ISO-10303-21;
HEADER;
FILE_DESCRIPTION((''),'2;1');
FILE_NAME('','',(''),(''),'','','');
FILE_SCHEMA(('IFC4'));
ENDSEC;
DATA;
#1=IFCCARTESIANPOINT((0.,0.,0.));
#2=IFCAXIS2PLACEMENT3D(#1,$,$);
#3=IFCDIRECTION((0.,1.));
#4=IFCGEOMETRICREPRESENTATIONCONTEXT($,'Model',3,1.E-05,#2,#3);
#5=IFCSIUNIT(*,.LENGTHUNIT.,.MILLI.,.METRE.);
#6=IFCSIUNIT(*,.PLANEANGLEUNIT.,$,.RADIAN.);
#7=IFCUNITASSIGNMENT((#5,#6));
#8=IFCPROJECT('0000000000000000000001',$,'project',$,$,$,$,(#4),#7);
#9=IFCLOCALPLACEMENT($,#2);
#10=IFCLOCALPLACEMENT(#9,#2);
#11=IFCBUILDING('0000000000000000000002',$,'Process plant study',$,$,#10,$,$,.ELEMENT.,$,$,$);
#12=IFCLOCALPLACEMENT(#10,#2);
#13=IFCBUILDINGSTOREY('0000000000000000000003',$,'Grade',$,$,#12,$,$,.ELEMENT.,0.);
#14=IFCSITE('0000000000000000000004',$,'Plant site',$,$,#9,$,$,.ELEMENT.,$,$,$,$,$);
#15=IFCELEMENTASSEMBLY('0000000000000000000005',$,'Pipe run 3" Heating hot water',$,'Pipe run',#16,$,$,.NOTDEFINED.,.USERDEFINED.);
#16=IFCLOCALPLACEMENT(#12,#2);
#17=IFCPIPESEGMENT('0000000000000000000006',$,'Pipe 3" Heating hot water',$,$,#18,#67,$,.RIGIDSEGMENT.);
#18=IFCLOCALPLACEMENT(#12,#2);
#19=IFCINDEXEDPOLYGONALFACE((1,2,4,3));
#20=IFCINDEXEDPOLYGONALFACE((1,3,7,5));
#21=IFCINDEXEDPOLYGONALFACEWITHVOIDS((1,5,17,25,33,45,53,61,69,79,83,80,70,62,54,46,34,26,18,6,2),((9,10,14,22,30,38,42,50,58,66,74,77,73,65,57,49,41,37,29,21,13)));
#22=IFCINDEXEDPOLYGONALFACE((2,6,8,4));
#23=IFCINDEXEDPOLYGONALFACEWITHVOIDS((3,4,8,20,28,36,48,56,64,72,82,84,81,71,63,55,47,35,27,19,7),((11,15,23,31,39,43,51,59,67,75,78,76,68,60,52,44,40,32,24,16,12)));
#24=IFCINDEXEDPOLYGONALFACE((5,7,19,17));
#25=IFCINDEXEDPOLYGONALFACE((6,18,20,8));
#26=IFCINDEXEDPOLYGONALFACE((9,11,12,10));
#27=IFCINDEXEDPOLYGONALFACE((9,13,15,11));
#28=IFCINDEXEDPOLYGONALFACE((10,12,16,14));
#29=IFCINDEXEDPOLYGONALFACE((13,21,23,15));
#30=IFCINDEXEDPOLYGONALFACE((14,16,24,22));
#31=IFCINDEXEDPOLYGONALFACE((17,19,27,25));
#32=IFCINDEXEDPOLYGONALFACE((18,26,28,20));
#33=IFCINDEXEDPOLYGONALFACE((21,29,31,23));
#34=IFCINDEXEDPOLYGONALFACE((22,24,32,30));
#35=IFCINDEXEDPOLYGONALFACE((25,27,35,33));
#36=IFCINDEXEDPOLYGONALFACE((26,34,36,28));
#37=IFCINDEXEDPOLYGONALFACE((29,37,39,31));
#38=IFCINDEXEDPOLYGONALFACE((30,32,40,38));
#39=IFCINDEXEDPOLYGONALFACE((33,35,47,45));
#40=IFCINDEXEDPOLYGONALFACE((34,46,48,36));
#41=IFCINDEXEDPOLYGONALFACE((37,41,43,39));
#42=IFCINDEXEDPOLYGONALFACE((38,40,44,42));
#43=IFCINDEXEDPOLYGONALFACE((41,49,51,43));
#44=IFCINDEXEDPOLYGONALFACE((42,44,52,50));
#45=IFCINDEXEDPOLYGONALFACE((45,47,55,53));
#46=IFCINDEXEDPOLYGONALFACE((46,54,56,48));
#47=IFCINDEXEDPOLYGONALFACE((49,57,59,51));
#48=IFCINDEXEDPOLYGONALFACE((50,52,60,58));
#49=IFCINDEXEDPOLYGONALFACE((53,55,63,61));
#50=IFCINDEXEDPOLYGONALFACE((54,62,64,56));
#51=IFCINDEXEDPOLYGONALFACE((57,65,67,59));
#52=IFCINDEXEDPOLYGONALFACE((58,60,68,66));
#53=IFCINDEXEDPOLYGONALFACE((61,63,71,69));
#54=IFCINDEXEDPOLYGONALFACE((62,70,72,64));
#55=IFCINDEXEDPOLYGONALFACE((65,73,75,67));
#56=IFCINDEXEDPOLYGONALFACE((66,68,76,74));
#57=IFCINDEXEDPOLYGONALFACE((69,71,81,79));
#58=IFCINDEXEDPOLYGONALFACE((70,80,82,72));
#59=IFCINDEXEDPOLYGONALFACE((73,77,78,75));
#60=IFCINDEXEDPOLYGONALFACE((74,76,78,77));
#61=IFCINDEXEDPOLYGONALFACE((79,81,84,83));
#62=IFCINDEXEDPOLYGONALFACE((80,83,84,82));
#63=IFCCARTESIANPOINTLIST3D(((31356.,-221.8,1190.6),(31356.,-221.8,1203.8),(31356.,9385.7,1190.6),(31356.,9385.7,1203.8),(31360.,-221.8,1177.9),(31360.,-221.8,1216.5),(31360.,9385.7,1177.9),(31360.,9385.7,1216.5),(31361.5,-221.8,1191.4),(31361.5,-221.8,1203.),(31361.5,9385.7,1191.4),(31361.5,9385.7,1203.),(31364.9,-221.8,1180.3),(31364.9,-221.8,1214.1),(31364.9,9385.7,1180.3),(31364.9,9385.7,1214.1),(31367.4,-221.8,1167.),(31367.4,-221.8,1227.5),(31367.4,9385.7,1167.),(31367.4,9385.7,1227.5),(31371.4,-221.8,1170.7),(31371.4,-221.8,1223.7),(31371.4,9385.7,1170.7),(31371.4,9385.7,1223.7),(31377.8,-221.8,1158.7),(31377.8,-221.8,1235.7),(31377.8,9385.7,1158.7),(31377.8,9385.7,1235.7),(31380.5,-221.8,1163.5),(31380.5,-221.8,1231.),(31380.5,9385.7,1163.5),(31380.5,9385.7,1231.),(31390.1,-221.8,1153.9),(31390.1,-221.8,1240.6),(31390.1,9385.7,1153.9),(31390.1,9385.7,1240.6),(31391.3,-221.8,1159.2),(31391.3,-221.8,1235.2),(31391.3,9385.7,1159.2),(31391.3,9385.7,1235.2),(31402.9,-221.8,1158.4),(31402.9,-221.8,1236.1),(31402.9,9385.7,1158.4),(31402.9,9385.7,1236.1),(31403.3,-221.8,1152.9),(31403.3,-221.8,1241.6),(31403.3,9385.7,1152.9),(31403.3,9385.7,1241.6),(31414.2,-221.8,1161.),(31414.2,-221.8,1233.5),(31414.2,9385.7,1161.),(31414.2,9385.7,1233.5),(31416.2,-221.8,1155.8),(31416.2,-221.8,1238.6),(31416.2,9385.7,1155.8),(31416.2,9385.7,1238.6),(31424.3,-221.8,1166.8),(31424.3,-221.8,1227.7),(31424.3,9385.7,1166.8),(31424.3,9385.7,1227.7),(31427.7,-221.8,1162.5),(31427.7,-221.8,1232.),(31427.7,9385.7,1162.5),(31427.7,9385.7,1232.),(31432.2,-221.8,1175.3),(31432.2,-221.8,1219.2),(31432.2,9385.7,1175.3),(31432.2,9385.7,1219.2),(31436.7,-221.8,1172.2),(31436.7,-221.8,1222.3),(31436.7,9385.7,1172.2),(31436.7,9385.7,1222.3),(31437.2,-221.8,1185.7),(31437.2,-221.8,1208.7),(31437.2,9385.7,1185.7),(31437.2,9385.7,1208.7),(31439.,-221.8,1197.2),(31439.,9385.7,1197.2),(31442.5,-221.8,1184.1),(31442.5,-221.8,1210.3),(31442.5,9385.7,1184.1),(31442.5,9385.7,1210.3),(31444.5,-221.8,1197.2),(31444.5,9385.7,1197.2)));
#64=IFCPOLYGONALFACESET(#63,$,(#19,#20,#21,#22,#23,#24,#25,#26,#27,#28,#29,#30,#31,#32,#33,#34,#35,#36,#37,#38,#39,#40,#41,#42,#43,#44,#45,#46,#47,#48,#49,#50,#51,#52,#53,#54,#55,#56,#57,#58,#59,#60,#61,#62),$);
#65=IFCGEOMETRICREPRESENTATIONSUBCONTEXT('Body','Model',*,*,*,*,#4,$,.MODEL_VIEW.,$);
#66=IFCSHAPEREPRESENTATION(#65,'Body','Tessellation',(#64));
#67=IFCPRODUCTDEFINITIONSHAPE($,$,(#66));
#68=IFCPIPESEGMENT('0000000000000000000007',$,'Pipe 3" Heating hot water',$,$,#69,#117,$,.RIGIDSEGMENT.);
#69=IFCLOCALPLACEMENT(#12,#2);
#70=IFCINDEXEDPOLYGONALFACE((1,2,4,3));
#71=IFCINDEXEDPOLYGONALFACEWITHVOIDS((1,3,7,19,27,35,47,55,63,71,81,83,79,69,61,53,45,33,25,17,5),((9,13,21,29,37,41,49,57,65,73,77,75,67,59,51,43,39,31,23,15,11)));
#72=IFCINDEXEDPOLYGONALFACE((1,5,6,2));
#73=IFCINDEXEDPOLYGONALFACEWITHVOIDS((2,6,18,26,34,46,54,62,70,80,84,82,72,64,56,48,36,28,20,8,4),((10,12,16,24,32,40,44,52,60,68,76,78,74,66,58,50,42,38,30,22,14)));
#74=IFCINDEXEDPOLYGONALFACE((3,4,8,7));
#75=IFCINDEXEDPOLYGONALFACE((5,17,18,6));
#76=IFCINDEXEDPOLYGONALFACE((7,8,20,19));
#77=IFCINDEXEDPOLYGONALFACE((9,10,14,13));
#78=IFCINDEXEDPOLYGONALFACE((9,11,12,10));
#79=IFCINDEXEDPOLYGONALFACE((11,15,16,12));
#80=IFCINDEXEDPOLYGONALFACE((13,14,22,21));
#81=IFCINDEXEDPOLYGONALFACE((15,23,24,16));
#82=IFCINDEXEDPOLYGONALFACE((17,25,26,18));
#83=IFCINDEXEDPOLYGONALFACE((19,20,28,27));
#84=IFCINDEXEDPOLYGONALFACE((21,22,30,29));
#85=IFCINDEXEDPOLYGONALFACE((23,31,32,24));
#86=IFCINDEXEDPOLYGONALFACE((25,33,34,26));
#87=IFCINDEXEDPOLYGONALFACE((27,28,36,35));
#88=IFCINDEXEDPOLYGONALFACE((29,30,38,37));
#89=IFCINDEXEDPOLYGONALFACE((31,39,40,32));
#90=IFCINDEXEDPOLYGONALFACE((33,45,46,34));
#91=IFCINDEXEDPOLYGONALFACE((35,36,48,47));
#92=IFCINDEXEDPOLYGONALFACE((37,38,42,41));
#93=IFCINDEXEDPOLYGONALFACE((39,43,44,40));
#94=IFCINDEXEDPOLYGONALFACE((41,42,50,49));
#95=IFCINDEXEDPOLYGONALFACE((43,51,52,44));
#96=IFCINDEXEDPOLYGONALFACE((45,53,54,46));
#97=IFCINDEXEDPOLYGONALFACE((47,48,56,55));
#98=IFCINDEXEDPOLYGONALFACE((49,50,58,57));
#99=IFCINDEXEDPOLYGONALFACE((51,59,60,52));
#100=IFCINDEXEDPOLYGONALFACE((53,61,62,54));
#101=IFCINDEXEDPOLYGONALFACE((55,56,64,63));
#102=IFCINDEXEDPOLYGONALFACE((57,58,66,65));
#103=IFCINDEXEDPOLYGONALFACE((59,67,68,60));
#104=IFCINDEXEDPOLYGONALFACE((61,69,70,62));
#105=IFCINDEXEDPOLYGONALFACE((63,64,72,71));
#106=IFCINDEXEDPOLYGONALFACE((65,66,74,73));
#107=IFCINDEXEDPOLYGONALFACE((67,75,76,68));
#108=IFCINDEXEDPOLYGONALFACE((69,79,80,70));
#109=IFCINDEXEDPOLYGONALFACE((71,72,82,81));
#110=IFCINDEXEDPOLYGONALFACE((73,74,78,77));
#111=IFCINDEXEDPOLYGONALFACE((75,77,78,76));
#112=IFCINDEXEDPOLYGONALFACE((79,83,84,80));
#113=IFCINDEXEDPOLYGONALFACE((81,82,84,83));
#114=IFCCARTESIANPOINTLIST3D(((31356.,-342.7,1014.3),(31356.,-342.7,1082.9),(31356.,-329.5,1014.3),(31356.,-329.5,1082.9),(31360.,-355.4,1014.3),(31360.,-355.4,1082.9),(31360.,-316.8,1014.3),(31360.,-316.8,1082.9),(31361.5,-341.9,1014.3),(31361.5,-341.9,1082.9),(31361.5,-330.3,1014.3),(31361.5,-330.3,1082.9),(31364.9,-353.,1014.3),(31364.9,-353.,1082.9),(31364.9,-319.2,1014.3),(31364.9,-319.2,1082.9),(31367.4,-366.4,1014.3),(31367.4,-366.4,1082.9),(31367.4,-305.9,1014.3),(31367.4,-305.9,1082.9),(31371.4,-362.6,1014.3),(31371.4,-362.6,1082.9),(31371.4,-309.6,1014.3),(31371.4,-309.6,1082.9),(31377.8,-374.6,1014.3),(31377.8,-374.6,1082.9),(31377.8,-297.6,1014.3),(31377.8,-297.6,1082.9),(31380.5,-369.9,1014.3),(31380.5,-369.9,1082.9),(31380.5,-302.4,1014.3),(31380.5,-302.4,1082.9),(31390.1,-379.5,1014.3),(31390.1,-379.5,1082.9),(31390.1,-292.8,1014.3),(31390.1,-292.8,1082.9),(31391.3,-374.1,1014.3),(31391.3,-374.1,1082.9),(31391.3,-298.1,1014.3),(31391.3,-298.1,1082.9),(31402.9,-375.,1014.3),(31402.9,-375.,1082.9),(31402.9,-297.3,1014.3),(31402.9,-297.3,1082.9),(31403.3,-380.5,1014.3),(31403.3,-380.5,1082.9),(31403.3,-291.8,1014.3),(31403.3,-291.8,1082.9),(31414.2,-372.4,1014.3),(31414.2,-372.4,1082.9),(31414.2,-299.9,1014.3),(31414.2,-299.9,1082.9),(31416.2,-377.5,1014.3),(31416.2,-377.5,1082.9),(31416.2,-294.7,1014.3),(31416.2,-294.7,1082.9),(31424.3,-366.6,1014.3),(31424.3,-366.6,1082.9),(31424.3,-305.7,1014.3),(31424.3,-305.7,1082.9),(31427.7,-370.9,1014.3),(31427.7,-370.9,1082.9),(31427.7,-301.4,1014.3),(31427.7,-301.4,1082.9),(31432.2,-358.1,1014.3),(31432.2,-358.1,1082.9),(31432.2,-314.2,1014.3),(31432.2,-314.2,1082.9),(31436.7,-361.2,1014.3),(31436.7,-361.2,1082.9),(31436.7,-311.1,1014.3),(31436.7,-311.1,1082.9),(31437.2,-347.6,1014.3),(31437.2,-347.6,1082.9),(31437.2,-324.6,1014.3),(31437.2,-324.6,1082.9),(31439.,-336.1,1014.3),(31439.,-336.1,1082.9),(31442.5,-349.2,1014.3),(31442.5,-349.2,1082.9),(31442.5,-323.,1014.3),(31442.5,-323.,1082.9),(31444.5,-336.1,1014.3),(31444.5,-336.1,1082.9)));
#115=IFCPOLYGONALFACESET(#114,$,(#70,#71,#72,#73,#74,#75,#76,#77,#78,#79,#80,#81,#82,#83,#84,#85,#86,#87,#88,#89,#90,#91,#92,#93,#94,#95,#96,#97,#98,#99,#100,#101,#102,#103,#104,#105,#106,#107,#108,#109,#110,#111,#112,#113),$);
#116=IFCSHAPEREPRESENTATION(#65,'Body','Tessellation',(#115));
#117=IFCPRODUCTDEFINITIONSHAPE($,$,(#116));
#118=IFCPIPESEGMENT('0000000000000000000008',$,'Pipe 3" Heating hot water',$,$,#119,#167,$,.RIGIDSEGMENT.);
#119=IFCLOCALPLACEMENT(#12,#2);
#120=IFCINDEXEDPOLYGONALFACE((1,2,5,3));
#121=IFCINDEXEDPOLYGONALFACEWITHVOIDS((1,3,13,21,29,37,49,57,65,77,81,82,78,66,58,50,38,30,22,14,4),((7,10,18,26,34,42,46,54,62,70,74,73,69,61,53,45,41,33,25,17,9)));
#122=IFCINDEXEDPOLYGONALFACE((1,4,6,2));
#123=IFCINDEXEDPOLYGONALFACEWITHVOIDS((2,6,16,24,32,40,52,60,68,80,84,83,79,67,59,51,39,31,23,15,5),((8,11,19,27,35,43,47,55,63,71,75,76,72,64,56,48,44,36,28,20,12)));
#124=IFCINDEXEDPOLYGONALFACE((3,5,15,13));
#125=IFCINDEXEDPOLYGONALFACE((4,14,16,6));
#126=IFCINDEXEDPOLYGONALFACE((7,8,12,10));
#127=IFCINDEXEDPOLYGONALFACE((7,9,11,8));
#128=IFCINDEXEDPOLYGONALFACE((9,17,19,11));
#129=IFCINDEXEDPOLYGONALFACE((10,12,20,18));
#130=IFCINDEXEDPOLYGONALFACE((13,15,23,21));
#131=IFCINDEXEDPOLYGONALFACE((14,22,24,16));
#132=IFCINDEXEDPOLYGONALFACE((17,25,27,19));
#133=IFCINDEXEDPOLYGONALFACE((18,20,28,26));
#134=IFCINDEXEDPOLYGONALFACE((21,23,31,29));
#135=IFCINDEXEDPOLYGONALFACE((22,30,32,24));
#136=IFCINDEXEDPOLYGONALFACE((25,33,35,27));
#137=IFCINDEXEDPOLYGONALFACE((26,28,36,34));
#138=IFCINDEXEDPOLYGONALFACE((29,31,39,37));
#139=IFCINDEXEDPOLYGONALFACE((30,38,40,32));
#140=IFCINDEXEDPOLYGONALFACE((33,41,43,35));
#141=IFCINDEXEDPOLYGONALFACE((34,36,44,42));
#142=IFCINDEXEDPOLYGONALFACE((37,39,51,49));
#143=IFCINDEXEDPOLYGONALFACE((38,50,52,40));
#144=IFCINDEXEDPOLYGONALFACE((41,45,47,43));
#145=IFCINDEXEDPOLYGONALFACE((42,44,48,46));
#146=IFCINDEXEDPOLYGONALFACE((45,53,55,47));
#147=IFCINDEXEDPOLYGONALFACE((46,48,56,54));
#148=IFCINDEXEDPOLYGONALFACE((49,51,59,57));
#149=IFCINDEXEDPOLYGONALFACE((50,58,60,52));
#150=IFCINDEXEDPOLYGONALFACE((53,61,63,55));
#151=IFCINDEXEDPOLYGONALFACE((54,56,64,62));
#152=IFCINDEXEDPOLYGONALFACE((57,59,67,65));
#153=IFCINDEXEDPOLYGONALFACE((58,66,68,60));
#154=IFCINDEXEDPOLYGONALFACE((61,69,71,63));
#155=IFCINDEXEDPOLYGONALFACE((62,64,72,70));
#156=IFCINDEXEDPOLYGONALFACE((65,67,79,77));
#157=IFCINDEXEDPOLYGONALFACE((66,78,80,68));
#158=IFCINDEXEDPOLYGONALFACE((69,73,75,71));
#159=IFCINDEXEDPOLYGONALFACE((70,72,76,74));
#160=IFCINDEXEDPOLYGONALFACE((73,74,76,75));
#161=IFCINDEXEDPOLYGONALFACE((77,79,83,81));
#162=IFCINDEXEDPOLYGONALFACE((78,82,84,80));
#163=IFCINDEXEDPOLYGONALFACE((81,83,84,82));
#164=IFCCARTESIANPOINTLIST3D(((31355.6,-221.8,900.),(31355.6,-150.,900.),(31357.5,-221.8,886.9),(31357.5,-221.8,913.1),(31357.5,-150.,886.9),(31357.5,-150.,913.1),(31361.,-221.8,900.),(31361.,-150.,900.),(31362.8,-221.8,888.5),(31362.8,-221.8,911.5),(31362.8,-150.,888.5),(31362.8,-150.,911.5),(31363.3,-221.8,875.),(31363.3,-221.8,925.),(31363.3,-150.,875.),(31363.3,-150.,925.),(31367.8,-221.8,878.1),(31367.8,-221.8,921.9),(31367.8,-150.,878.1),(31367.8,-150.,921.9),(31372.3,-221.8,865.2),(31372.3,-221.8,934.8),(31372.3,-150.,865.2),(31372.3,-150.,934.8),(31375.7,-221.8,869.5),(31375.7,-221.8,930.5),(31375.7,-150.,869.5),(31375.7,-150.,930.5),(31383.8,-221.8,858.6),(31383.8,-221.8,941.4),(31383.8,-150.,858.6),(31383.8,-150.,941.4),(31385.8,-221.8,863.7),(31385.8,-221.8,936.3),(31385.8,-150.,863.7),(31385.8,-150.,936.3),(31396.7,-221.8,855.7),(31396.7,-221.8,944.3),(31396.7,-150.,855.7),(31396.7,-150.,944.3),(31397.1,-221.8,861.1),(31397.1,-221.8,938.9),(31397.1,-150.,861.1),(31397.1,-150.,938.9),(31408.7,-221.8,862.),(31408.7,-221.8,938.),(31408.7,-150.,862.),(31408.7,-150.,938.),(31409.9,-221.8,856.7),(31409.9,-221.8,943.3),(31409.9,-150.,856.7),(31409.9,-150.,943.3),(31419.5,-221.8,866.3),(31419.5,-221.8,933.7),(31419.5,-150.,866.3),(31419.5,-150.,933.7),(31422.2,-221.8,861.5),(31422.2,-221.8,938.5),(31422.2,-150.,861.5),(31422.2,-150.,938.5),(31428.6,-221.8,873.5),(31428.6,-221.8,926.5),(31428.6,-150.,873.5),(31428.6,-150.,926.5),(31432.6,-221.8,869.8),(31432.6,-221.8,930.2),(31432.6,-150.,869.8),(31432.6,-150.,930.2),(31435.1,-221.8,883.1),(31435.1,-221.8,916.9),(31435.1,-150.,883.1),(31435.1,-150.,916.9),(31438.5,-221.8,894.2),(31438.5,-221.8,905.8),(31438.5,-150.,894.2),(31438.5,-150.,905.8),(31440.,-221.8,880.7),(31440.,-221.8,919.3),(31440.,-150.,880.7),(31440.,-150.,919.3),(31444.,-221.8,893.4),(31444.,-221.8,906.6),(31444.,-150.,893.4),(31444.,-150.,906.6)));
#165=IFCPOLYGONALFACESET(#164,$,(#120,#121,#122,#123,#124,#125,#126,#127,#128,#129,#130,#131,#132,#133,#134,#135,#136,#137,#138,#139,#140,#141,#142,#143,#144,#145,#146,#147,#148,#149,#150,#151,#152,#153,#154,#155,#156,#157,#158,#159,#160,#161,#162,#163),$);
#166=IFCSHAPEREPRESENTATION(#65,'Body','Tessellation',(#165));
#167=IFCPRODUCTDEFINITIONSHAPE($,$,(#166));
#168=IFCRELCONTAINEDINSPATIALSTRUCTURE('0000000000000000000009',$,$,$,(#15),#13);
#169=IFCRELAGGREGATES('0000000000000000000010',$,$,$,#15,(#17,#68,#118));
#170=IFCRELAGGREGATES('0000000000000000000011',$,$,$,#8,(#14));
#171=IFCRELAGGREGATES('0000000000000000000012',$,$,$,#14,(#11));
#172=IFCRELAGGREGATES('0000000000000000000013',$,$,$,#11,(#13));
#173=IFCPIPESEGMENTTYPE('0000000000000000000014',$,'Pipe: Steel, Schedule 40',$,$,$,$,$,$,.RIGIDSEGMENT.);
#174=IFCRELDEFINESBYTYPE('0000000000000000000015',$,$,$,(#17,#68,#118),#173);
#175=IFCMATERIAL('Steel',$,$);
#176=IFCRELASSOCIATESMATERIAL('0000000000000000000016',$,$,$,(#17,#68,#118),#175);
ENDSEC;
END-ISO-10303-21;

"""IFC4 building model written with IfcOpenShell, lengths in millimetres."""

from ifc_helpers import new_model, si_unit, direction, frame, origin, origin_with_axes, origin_2d, place, context, subcontext, project, spatial, hollow_circle, extrude, material, type_object, element, aggregate, save


model = new_model("IFC4")

# Units and contexts
model_context = context("Model", 3, precision=1e-05, world=origin(), true_north=direction((0.0, 1.0)))
body_context = subcontext(model_context, "Body", "Model", "MODEL_VIEW")
ifc_project = project(units=[si_unit("LENGTHUNIT", "METRE", prefix="MILLI"), si_unit("PLANEANGLEUNIT", "RADIAN")], contexts=[model_context])

# Site, building, storey
site_placement = place(None, origin())
site = spatial("IfcSite", under=ifc_project, at=site_placement, Name="Plant site", CompositionType="ELEMENT")
building_placement = place(site_placement, origin())
building = spatial("IfcBuilding", under=site, at=building_placement, Name="Process plant study", CompositionType="ELEMENT")
storey_placement = place(building_placement, origin())
storey = spatial("IfcBuildingStorey", under=building, at=storey_placement, Name="Grade", CompositionType="ELEMENT", Elevation=0.0)

# Shared definitions
ifc_material = material(Name="Steel")
pipe_segment_type = type_object("IfcPipeSegmentType", Name="Pipe: Steel, Schedule 40", PredefinedType="RIGIDSEGMENT")

# Element assembly, pipe segments
assembly_1_placement = place(storey_placement, origin_with_axes())
assembly_1 = element("IfcElementAssembly", 1, at=assembly_1_placement, inside=storey, Name="Pipe run 3\" Heating hot water", ObjectType="Pipe run", AssemblyPlace="NOTDEFINED", PredefinedType="USERDEFINED")
pipe_segment_1_placement = place(storey_placement, origin_with_axes())
pipe_segment_1 = element("IfcPipeSegment", 2, at=pipe_segment_1_placement, type_object=pipe_segment_type, material=ifc_material, Name="Pipe 3\" Heating hot water", PredefinedType="RIGIDSEGMENT", context=body_context, shape_type="SweptSolid", body=[
    extrude(hollow_circle(Radius=44.5, WallThickness=5.5, at=origin_2d()), frame((31400.0, 9385.7, 1197.2), z_axis=(0.0, -1.0, 0.0), x_axis=(1.0, 0.0, 0.0)), (0.0, 0.0, 1.0), 9607.5),
])
pipe_segment_2_placement = place(storey_placement, origin_with_axes())
pipe_segment_2 = element("IfcPipeSegment", 3, at=pipe_segment_2_placement, type_object=pipe_segment_type, material=ifc_material, Name="Pipe 3\" Heating hot water", PredefinedType="RIGIDSEGMENT", context=body_context, shape_type="SweptSolid", body=[
    extrude(hollow_circle(Radius=44.5, WallThickness=5.5, at=origin_2d()), frame((31400.0, -336.1, 1082.9), z_axis=(0.0, 0.0, -1.0), x_axis=(1.0, 0.0, 0.0)), (0.0, 0.0, 1.0), 68.6),
])
pipe_segment_3_placement = place(storey_placement, origin_with_axes())
pipe_segment_3 = element("IfcPipeSegment", 4, at=pipe_segment_3_placement, type_object=pipe_segment_type, material=ifc_material, Name="Pipe 3\" Heating hot water", PredefinedType="RIGIDSEGMENT", context=body_context, shape_type="SweptSolid", body=[
    extrude(hollow_circle(Radius=44.5, WallThickness=5.5, at=origin_2d()), frame((31400.0, -221.8, 900.0), z_axis=(0.0, 1.0, 0.0), x_axis=(-1.0, 0.0, 0.0)), (0.0, 0.0, 1.0), 71.8),
])

aggregate(assembly_1, [pipe_segment_1, pipe_segment_2, pipe_segment_3])

save(model, "model.ifc")
